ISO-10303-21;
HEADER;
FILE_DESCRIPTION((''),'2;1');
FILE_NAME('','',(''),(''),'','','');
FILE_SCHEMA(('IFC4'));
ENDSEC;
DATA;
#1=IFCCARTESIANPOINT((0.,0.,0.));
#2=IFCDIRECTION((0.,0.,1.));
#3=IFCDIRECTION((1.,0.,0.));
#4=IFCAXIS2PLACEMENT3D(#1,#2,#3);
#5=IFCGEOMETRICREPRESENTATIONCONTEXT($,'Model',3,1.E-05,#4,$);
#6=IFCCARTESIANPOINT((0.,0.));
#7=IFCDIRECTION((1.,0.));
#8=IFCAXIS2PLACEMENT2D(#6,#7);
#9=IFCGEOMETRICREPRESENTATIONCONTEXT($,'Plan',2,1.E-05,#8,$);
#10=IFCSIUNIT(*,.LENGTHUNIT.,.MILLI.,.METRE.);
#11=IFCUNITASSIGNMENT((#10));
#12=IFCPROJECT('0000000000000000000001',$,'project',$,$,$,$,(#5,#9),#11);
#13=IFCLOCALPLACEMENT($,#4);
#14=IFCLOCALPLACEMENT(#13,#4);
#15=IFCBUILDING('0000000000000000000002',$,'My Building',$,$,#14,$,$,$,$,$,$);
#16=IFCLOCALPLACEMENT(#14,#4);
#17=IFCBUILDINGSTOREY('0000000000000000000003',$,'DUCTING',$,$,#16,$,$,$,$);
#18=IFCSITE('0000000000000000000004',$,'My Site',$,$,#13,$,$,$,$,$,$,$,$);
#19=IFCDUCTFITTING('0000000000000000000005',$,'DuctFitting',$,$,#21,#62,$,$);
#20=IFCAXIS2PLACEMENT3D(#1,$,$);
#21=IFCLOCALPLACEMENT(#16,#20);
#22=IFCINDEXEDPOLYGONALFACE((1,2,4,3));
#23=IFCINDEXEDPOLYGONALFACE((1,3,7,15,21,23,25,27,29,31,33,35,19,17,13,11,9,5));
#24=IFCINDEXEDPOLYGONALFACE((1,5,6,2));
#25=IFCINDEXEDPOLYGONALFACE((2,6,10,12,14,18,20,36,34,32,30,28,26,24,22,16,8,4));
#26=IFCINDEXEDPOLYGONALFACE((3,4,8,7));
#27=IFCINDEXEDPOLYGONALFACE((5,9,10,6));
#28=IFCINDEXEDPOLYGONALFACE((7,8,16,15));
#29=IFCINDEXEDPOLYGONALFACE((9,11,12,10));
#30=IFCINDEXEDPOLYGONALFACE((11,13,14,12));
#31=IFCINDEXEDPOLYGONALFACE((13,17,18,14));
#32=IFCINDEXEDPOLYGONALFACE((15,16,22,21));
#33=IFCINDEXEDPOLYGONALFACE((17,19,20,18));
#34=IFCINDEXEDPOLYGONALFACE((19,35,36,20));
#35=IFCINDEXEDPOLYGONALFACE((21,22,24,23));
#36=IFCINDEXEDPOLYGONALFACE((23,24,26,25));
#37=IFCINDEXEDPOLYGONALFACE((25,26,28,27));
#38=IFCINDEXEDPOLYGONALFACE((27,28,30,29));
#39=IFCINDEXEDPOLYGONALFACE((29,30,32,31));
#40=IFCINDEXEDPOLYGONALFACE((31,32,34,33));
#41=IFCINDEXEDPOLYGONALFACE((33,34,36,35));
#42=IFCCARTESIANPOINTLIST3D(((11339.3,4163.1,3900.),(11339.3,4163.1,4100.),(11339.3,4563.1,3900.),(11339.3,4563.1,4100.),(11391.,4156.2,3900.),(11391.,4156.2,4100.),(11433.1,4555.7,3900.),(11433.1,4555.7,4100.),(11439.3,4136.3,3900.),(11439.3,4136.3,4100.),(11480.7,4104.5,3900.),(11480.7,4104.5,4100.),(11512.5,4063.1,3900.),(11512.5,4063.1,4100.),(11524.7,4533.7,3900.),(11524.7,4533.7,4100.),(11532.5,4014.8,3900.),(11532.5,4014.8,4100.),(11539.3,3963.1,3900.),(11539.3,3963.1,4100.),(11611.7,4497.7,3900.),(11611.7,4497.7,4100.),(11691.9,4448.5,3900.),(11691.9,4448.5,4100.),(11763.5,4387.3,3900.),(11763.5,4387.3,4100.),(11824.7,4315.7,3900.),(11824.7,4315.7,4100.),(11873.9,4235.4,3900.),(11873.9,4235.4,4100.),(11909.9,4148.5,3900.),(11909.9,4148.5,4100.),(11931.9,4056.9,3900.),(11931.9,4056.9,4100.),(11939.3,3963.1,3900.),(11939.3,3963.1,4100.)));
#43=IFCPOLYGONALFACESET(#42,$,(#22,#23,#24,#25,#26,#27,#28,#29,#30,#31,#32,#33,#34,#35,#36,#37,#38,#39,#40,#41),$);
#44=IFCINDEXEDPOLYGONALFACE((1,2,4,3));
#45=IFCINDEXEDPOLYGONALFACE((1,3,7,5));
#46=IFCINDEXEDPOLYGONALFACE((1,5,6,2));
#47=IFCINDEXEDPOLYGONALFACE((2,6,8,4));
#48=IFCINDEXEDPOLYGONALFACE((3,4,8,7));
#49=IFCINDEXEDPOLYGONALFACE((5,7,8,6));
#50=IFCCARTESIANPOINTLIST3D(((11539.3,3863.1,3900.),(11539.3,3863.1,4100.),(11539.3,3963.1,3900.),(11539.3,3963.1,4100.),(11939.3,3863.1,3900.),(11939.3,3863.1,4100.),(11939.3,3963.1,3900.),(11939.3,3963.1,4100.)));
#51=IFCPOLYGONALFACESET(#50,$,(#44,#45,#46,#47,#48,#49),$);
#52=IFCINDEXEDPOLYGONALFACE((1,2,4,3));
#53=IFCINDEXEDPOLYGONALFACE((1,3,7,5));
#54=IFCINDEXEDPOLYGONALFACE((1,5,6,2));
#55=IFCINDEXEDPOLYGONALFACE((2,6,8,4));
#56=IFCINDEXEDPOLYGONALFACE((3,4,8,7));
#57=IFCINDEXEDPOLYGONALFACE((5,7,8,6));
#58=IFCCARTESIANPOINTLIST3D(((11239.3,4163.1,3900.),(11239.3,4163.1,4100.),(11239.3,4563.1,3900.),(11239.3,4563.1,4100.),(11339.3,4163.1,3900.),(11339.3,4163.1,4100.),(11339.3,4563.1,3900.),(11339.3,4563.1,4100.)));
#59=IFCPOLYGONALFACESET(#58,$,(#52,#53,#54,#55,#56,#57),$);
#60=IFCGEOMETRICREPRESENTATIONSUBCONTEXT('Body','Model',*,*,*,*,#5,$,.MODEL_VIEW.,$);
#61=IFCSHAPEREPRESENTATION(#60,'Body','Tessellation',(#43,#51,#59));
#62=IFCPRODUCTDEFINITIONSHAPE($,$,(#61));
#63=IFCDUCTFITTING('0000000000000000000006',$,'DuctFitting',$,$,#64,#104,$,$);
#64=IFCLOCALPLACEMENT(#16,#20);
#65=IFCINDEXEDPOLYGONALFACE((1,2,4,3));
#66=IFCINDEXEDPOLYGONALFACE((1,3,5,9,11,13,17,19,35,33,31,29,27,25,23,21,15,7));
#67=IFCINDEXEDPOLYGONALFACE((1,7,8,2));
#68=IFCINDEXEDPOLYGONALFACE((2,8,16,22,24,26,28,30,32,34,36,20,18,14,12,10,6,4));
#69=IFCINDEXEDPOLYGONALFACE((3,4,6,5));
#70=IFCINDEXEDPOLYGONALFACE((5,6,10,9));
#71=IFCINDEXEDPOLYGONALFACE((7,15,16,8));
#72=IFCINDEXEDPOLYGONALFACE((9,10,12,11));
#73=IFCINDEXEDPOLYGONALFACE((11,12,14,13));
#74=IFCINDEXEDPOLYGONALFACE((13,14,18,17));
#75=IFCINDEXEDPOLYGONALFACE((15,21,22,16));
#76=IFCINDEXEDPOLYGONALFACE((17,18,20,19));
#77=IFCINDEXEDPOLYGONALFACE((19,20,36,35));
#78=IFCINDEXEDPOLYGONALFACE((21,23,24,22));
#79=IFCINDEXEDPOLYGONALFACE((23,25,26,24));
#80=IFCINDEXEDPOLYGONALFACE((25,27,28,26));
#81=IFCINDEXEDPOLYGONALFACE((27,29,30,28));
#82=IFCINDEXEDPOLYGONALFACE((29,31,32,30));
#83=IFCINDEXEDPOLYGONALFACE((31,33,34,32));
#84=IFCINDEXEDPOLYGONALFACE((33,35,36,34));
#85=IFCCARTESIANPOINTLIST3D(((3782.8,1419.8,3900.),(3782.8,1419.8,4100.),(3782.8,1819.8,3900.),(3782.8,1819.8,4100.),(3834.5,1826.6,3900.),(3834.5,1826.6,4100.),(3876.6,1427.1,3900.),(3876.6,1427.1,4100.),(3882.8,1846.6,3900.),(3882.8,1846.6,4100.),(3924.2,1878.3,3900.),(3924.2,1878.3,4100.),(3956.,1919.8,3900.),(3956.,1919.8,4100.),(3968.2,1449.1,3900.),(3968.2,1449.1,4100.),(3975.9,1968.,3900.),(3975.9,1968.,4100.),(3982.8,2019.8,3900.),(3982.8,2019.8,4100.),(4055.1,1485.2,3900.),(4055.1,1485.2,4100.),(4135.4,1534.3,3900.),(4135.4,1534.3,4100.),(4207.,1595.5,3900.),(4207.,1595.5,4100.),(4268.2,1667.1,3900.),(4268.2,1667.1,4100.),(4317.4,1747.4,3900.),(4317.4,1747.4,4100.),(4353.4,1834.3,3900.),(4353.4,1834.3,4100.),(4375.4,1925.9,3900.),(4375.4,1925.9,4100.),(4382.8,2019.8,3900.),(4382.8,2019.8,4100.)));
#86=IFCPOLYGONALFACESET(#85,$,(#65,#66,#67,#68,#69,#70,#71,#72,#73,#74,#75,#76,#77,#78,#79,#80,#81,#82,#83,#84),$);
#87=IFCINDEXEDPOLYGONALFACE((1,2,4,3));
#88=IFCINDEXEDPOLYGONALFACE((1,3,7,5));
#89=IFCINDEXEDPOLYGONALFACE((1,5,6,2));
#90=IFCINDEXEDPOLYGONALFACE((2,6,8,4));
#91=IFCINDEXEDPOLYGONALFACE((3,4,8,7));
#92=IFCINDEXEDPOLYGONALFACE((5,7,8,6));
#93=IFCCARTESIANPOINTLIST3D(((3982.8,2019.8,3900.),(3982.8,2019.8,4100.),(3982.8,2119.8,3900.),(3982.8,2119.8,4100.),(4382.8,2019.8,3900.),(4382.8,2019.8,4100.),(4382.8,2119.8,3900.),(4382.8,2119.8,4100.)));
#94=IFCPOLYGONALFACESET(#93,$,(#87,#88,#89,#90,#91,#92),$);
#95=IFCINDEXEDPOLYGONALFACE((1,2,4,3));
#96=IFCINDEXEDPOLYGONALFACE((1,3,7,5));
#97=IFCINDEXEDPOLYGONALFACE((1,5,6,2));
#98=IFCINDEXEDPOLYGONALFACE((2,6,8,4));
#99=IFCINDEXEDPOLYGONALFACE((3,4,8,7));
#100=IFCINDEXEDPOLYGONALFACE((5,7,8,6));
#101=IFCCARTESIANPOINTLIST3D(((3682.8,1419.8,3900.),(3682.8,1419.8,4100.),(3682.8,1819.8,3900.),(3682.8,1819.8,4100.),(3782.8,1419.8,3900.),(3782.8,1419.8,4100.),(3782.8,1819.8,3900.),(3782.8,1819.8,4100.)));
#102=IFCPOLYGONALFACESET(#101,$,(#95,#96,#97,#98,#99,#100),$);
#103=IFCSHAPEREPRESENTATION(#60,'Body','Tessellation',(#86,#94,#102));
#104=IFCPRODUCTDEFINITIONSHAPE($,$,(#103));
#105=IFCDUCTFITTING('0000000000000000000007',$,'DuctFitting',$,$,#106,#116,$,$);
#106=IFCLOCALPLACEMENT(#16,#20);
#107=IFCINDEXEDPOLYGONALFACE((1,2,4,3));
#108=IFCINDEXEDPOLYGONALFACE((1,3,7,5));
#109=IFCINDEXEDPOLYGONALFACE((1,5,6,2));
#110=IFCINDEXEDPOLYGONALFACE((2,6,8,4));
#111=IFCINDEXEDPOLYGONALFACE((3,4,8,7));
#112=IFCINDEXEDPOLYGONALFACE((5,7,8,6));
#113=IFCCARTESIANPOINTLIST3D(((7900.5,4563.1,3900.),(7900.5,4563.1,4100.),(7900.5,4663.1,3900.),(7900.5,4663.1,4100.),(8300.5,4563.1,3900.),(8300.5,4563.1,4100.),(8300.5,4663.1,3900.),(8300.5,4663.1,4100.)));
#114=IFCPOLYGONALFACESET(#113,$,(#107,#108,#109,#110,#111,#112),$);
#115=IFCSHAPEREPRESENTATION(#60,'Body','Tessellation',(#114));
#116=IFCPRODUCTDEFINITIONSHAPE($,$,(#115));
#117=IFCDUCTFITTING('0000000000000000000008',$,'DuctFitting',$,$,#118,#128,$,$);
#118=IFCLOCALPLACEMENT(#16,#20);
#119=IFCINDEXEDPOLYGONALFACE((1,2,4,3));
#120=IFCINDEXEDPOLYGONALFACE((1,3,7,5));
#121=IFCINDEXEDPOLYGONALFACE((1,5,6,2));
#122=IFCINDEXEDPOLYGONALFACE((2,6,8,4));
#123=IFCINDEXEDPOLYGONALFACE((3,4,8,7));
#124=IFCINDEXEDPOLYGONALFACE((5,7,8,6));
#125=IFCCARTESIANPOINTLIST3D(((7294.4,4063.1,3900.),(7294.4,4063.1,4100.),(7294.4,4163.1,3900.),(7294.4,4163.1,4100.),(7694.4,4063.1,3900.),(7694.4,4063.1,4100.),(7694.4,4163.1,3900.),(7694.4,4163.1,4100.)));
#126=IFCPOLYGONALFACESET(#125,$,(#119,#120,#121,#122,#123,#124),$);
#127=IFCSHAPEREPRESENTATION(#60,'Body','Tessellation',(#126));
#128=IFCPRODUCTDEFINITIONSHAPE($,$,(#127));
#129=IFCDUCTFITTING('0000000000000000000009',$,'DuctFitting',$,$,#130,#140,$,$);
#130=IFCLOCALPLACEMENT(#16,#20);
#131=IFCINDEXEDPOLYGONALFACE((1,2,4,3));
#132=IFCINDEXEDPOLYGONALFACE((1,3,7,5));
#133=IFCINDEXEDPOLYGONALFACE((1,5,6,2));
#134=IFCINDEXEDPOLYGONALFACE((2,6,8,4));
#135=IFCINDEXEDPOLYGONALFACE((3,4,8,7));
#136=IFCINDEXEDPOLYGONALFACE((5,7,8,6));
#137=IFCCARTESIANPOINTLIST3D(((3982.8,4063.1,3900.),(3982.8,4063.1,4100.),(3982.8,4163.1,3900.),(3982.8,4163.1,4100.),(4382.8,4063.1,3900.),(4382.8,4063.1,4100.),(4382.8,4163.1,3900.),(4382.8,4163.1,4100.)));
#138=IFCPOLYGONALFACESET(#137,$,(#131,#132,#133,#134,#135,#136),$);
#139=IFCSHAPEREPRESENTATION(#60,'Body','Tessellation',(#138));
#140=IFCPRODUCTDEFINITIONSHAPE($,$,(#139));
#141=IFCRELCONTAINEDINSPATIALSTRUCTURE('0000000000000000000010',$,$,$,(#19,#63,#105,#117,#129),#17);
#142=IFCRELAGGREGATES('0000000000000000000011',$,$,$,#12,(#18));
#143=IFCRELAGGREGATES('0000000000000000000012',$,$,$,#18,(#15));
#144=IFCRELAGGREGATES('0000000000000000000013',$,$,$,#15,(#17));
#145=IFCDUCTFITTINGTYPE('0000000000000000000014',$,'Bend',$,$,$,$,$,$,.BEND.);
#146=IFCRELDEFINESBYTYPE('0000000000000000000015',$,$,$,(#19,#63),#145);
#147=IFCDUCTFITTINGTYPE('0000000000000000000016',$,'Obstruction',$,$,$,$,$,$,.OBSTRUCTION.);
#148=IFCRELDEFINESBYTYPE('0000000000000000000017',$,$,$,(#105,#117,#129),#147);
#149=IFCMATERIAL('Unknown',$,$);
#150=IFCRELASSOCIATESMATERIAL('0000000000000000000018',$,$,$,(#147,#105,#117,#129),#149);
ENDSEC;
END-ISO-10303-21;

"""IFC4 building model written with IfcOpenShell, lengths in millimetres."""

from ifc_helpers import new_model, si_unit, frame, origin_with_axes, origin_2d_with_axis, place, context, subcontext, project, spatial, line, arc, indexed_curve, rectangle, outline, extrude, source, transform, mapped, material, material_profile, profile_set, profile_usage, type_object, type_shapes, element, save


model = new_model("IFC4")

# Units and contexts
model_context = context("Model", 3, precision=1e-05, world=origin_with_axes())
plan_context = context("Plan", 2, precision=1e-05, world=origin_2d_with_axis())
body_context = subcontext(model_context, "Body", "Model", "MODEL_VIEW")
ifc_project = project(units=[si_unit("LENGTHUNIT", "METRE", prefix="MILLI")], contexts=[model_context, plan_context])

# Site, building, storey
site_placement = place(None, origin_with_axes())
site = spatial("IfcSite", under=ifc_project, at=site_placement, Name="My Site")
building_placement = place(site_placement, origin_with_axes())
building = spatial("IfcBuilding", under=site, at=building_placement, Name="My Building")
storey_placement = place(building_placement, origin_with_axes())
storey = spatial("IfcBuildingStorey", under=building, at=storey_placement, Name="DUCTING")

# Shared definitions
ifc_material = material(Name="Unknown")

# Duct fittings
duct_fitting_type_1 = type_object("IfcDuctFittingType", Name="Bend", PredefinedType="BEND")
shared_shape = source(origin_with_axes(), body_context, "Body", "SweptSolid", [
    extrude(outline(indexed_curve([(-200.0, 0.0), (-258.6, 141.4), (-400.0, 200.0), (-400.0, 600.0), (24.3, 424.3), (200.0, 0.0)], segments=[arc(1, 2, 3), line(3, 4), arc(4, 5, 6), line(6, 1)])), frame((0.0, -100.0, 100.0), z_axis=(0.0, -1.0, 0.0), x_axis=(1.0, 0.0, 0.0)), (0.0, 0.0, -1.0), 200.0),
    extrude(rectangle(XDim=400.0, YDim=200.0), origin_with_axes(), (0.0, 0.0, 1.0), 100.0),
    extrude(rectangle(XDim=400.0, YDim=200.0), frame((-400.0, 0.0, 500.0), z_axis=(-1.0, 0.0, 0.0), x_axis=(0.0, 0.0, -1.0)), (0.0, 0.0, 1.0), 100.0),
])
type_shapes(duct_fitting_type_1, [shared_shape])
for number, where, z_axis, x_axis, name in (
    (1, (11739.3, 3863.1, 4000.0), (0.0, 1.0, 0.0), (1.0, 0.0, 0.0), "DuctFitting"),
    (2, (4182.8, 2119.8, 4000.0), (0.0, -1.0, 0.0), (1.0, 0.0, 0.0), "DuctFitting"),
):
    element("IfcDuctFitting", number, at=place(storey_placement, frame(where, z_axis=z_axis, x_axis=x_axis)), inside=storey, type_object=duct_fitting_type_1, Name=name, context=body_context, shape_type="MappedRepresentation", body=[
        mapped(shared_shape, transform((0.0, 0.0, 0.0), x_axis=(1.0, 0.0, 0.0), y_axis=(0.0, 1.0, 0.0), z_axis=(0.0, 0.0, 1.0), scale=1.0)),
    ])
ifc_material_profile_1 = material_profile(ifc_material, rectangle(XDim=400.0, YDim=200.0))
ifc_profile_set_1 = profile_set([ifc_material_profile_1])
ifc_profile_usage_1 = profile_usage(ifc_profile_set_1, cardinal=5)
duct_fitting_type_2 = type_object("IfcDuctFittingType", Name="Obstruction", PredefinedType="OBSTRUCTION", material=ifc_profile_set_1)
duct_fitting_1_placement = place(storey_placement, frame((8100.5, 4663.1, 4000.0), z_axis=(0.0, -1.0, 0.0), x_axis=(1.0, 0.0, 0.0)))
element("IfcDuctFitting", 3, at=duct_fitting_1_placement, inside=storey, type_object=duct_fitting_type_2, material=ifc_profile_usage_1, Name="DuctFitting", context=body_context, shape_type="SweptSolid", body=[
    extrude(rectangle(XDim=400.0, YDim=200.0), origin_with_axes(), (0.0, 0.0, 1.0), 100.0),
])
ifc_profile_usage_2 = profile_usage(ifc_profile_set_1, cardinal=5)
duct_fitting_2_placement = place(storey_placement, frame((7494.4, 4163.1, 4000.0), z_axis=(0.0, -1.0, 0.0), x_axis=(1.0, 0.0, 0.0)))
element("IfcDuctFitting", 4, at=duct_fitting_2_placement, inside=storey, type_object=duct_fitting_type_2, material=ifc_profile_usage_2, Name="DuctFitting", context=body_context, shape_type="SweptSolid", body=[
    extrude(rectangle(XDim=400.0, YDim=200.0), origin_with_axes(), (0.0, 0.0, 1.0), 100.0),
])
ifc_profile_usage_3 = profile_usage(ifc_profile_set_1, cardinal=5)
duct_fitting_3_placement = place(storey_placement, frame((4182.8, 4163.1, 4000.0), z_axis=(0.0, -1.0, 0.0), x_axis=(1.0, 0.0, 0.0)))
element("IfcDuctFitting", 5, at=duct_fitting_3_placement, inside=storey, type_object=duct_fitting_type_2, material=ifc_profile_usage_3, Name="DuctFitting", context=body_context, shape_type="SweptSolid", body=[
    extrude(rectangle(XDim=400.0, YDim=200.0), origin_with_axes(), (0.0, 0.0, 1.0), 100.0),
])

save(model, "model.ifc")
